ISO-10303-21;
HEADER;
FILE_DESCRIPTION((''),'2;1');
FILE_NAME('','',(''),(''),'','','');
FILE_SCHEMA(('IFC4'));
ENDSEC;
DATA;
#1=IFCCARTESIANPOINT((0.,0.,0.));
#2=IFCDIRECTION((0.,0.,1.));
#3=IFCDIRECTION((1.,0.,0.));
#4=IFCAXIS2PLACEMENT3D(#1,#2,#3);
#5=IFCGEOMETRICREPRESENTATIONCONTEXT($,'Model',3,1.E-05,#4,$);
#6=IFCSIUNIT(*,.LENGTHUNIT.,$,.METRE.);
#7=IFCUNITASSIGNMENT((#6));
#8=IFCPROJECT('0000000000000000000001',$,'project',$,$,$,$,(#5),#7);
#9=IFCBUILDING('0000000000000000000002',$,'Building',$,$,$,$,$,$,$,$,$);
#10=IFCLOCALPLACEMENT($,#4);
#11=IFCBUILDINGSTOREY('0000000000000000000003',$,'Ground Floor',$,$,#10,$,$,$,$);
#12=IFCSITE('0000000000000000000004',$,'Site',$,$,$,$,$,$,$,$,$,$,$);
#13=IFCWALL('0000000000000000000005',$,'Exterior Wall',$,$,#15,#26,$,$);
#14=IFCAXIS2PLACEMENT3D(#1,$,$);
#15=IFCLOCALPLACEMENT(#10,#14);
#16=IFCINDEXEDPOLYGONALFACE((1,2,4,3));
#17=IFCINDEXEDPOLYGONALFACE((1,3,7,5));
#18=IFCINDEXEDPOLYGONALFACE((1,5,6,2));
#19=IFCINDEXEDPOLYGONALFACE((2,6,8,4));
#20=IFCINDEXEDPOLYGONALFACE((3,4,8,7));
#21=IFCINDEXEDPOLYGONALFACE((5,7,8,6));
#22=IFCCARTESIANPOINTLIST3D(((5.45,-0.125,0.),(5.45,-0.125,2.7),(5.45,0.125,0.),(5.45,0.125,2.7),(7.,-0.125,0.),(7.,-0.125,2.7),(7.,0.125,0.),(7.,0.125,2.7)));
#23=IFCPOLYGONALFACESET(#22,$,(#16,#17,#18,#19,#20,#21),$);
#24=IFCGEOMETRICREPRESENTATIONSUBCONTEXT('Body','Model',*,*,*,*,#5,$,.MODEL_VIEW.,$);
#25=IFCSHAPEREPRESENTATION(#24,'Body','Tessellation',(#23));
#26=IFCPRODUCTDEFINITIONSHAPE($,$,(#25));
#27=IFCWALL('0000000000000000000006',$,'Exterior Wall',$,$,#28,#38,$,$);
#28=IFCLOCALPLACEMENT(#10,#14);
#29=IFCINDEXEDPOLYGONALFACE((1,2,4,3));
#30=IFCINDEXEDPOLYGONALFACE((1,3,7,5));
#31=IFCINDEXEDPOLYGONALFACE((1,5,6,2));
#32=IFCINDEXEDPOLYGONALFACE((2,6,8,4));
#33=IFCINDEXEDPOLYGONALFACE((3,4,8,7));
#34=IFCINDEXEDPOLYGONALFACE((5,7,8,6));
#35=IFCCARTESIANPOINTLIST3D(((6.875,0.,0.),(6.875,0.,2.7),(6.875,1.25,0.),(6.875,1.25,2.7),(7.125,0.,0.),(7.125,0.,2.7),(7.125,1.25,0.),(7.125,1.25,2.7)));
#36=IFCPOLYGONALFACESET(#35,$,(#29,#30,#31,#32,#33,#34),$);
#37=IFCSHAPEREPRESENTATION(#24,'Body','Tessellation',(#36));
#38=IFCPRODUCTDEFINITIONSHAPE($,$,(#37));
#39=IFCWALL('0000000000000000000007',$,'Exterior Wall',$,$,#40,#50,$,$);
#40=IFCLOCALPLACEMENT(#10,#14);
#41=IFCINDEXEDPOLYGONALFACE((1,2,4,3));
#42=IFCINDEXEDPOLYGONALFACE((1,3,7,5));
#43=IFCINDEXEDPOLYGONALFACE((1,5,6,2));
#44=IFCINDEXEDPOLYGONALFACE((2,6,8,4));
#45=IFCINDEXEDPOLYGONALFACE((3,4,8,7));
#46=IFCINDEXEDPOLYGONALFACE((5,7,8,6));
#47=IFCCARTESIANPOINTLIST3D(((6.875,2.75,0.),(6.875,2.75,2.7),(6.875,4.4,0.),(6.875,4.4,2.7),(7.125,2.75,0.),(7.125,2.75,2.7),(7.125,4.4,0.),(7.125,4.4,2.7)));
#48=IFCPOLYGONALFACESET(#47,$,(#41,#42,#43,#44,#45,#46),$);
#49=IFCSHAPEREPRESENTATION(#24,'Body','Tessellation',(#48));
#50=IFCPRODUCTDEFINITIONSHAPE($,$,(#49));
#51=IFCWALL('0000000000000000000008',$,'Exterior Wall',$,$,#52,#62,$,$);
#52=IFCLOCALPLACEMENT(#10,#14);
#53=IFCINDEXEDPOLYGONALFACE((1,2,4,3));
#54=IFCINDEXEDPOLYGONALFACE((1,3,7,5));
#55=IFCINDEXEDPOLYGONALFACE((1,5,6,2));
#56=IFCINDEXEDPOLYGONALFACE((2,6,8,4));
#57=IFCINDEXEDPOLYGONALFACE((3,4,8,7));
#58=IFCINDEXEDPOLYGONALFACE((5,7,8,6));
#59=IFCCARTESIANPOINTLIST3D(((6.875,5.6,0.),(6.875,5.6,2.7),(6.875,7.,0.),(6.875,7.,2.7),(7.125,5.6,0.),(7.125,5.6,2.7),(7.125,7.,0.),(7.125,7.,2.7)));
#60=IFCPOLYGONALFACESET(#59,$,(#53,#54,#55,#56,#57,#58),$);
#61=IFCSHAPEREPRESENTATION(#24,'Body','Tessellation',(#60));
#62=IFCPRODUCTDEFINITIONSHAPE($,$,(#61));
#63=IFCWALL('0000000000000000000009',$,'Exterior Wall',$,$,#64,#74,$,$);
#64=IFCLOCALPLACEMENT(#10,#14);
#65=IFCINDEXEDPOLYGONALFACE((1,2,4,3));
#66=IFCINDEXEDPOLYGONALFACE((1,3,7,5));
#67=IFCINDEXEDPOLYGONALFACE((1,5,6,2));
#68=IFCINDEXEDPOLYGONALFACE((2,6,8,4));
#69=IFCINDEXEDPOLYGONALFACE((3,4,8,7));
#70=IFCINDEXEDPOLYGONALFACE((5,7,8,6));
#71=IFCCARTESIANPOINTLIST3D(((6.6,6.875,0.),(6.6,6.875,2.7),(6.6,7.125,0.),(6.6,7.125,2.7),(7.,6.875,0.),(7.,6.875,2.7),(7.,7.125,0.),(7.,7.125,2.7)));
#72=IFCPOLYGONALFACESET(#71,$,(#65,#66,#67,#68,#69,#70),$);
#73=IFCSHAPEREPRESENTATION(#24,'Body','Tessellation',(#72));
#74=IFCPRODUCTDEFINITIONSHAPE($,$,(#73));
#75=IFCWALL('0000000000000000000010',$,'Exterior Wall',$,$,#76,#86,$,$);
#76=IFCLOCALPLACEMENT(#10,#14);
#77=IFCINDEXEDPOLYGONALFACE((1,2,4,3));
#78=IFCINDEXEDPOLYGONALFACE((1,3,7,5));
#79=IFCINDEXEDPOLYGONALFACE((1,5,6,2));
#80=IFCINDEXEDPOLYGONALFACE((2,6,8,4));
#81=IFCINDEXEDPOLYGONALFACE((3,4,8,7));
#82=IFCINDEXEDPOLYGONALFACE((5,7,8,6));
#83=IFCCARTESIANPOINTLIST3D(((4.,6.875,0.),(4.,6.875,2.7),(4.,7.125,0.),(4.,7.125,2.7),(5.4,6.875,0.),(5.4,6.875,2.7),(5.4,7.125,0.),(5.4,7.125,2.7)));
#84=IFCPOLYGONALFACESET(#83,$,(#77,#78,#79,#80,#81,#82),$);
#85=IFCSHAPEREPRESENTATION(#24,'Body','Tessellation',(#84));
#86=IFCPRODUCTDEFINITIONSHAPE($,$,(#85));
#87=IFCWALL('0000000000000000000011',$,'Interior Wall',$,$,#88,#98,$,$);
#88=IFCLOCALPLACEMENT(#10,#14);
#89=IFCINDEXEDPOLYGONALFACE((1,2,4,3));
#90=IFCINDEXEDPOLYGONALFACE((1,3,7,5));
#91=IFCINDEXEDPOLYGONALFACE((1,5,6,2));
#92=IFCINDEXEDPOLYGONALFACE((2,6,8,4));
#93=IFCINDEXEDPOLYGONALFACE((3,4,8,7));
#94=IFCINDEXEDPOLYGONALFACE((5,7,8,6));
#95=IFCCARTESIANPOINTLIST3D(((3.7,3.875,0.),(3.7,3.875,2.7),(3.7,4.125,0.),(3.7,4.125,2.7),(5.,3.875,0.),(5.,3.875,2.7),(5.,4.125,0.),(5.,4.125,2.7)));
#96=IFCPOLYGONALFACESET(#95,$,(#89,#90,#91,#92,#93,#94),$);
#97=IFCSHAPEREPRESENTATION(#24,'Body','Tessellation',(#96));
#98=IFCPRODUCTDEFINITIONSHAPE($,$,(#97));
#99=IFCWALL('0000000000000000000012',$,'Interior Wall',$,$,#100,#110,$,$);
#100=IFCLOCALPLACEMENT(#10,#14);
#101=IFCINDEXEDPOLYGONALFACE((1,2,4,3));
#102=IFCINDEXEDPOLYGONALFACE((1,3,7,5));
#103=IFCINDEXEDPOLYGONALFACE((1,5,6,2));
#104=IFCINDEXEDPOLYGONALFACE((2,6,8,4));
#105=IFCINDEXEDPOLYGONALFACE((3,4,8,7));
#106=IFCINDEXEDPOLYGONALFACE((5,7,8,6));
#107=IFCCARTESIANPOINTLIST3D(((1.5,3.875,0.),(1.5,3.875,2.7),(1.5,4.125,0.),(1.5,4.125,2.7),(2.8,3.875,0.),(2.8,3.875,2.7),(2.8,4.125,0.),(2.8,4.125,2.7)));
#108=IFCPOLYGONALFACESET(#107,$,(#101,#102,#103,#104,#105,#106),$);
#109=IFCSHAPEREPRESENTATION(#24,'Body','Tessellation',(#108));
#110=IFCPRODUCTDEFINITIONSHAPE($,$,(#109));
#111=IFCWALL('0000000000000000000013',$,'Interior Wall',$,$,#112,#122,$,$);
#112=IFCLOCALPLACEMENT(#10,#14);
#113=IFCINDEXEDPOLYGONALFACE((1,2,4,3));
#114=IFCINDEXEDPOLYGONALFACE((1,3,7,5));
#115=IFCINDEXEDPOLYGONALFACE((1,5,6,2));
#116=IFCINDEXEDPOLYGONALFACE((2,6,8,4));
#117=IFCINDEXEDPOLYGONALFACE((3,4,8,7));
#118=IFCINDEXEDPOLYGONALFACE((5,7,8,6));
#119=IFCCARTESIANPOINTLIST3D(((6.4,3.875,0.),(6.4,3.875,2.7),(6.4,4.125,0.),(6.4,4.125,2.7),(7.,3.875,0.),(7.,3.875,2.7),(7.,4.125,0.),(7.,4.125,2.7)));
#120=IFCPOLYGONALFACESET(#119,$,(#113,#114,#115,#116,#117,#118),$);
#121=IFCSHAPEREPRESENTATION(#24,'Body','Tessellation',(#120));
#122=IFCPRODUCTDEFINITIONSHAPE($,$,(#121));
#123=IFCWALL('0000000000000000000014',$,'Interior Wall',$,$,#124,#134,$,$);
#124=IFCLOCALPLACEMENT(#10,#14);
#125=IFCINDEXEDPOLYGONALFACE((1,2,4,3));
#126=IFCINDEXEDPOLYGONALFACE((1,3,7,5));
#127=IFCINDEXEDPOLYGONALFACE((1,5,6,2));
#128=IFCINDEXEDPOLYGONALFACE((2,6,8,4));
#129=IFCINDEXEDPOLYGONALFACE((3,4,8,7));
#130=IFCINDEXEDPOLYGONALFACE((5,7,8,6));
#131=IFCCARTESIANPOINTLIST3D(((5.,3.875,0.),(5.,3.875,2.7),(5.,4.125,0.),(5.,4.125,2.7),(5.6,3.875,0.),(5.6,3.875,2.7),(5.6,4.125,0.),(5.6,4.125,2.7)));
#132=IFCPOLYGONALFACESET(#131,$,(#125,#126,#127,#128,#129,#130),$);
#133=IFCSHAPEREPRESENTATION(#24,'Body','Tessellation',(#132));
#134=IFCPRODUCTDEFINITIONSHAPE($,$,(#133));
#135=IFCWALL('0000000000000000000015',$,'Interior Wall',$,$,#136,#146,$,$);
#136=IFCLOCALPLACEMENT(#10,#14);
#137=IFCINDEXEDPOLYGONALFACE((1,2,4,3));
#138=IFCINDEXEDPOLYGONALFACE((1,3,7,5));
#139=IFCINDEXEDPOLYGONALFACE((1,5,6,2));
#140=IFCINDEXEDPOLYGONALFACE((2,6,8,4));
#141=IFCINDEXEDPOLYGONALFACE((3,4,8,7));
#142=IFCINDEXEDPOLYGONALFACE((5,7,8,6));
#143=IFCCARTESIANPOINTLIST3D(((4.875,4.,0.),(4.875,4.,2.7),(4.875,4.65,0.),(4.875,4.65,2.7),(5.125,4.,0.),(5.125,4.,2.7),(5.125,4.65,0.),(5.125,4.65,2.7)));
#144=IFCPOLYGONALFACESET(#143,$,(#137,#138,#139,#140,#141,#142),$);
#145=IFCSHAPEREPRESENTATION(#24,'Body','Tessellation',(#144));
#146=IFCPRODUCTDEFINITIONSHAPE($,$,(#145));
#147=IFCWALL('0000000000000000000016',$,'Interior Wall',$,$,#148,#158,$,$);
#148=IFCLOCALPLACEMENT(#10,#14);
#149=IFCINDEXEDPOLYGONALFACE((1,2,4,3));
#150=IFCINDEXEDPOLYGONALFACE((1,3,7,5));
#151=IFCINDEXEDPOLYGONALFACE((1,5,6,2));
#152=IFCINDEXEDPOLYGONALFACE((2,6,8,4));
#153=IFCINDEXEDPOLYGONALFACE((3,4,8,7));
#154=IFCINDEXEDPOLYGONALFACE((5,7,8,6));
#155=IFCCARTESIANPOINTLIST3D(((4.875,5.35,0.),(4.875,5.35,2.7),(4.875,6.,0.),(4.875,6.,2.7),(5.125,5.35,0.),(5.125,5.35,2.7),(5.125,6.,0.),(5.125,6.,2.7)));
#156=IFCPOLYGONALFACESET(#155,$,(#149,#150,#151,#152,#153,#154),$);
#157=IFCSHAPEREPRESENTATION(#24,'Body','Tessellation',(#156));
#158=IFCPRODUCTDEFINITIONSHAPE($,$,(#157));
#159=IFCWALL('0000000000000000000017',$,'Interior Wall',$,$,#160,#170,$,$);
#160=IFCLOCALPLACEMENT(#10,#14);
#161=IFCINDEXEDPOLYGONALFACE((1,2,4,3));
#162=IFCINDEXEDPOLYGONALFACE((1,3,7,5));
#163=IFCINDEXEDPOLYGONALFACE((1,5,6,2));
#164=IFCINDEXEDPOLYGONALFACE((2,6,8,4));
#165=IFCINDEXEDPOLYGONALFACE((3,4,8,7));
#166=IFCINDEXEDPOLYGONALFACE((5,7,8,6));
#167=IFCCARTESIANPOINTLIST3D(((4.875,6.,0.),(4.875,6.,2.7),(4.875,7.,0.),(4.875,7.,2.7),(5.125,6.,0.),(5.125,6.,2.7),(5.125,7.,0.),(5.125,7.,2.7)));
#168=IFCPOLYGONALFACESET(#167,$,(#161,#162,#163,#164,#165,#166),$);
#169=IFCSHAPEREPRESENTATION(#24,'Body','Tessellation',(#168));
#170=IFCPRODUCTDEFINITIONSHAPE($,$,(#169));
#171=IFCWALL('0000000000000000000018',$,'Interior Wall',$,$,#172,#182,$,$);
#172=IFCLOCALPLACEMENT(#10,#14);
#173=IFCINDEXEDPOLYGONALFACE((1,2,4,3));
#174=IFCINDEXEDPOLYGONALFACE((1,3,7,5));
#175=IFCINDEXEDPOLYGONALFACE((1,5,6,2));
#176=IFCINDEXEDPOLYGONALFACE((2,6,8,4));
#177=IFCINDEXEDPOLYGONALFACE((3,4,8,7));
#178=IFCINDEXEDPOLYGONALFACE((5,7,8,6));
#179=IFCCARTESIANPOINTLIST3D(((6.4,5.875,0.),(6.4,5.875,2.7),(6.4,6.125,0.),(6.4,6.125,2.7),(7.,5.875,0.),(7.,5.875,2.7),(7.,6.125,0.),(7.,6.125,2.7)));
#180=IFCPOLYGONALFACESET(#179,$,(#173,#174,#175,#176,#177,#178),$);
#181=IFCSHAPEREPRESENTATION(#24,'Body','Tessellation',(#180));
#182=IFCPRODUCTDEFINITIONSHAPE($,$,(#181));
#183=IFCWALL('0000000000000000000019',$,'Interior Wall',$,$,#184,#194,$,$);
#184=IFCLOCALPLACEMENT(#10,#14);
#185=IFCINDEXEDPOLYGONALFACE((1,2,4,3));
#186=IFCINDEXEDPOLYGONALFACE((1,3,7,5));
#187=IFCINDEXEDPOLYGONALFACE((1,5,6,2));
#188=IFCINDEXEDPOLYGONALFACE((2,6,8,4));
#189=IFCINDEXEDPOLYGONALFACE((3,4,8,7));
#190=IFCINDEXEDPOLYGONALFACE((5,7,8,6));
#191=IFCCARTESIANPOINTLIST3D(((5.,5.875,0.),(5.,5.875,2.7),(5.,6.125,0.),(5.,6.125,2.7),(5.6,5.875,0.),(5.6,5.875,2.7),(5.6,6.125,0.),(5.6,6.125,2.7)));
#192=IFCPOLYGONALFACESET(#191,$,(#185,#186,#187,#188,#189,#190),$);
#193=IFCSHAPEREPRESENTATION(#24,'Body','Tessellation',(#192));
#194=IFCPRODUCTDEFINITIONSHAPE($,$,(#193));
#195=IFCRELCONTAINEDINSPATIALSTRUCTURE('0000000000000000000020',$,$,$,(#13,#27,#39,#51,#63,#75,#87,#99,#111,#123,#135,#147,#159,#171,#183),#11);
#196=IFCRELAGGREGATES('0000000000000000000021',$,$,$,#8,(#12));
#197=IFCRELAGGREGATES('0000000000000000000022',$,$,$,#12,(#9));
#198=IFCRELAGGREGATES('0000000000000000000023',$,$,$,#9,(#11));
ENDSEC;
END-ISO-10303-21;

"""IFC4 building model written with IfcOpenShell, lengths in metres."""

from ifc_helpers import new_model, si_unit, frame, origin_with_axes, place, context, subcontext, project, spatial, indexed_curve, outline, extrude, element, save


model = new_model("IFC4")

# Units and contexts
model_context = context("Model", 3, precision=1e-05, world=origin_with_axes())
body_context = subcontext(model_context, "Body", "Model", "MODEL_VIEW")
ifc_project = project(units=[si_unit("LENGTHUNIT", "METRE")], contexts=[model_context])

# Site, building, storey
site = spatial("IfcSite", under=ifc_project, Name="Site")
building = spatial("IfcBuilding", under=site, Name="Building")
storey_placement = place(None, origin_with_axes())
storey = spatial("IfcBuildingStorey", under=building, at=storey_placement, Name="Ground Floor")

# Walls
wall_1_placement = place(storey_placement, frame((5.45, 0.0, 0.0), z_axis=(0.0, 0.0, 1.0), x_axis=(1.0, 0.0, 0.0)))
element("IfcWall", 1, at=wall_1_placement, inside=storey, Name="Exterior Wall", context=body_context, shape_type="SweptSolid", body=[
    extrude(outline(indexed_curve([(0.0, 0.0), (0.0, 0.25), (1.55, 0.25), (1.55, 0.0), (0.0, 0.0)], self_intersect=False)), frame((0.0, -0.125, 0.0), z_axis=(0.0, 0.0, 1.0), x_axis=(1.0, 0.0, 0.0)), (0.0, 0.0, 1.0), 2.7),
])
wall_2_placement = place(storey_placement, frame((7.0, 0.0, 0.0), z_axis=(0.0, 0.0, 1.0), x_axis=(0.0, 1.0, 0.0)))
element("IfcWall", 2, at=wall_2_placement, inside=storey, Name="Exterior Wall", context=body_context, shape_type="SweptSolid", body=[
    extrude(outline(indexed_curve([(0.0, 0.0), (0.0, 0.25), (1.25, 0.25), (1.25, 0.0), (0.0, 0.0)], self_intersect=False)), frame((0.0, -0.125, 0.0), z_axis=(0.0, 0.0, 1.0), x_axis=(1.0, 0.0, 0.0)), (0.0, 0.0, 1.0), 2.7),
])
wall_3_placement = place(storey_placement, frame((7.0, 2.75, 0.0), z_axis=(0.0, 0.0, 1.0), x_axis=(0.0, 1.0, 0.0)))
element("IfcWall", 3, at=wall_3_placement, inside=storey, Name="Exterior Wall", context=body_context, shape_type="SweptSolid", body=[
    extrude(outline(indexed_curve([(0.0, 0.0), (0.0, 0.25), (1.65, 0.25), (1.65, 0.0), (0.0, 0.0)], self_intersect=False)), frame((0.0, -0.125, 0.0), z_axis=(0.0, 0.0, 1.0), x_axis=(1.0, 0.0, 0.0)), (0.0, 0.0, 1.0), 2.7),
])
wall_4_placement = place(storey_placement, frame((7.0, 5.6, 0.0), z_axis=(0.0, 0.0, 1.0), x_axis=(0.0, 1.0, 0.0)))
element("IfcWall", 4, at=wall_4_placement, inside=storey, Name="Exterior Wall", context=body_context, shape_type="SweptSolid", body=[
    extrude(outline(indexed_curve([(0.0, 0.0), (0.0, 0.25), (1.4, 0.25), (1.4, 0.0), (0.0, 0.0)], self_intersect=False)), frame((0.0, -0.125, 0.0), z_axis=(0.0, 0.0, 1.0), x_axis=(1.0, 0.0, 0.0)), (0.0, 0.0, 1.0), 2.7),
])
wall_5_placement = place(storey_placement, frame((7.0, 7.0, 0.0), z_axis=(0.0, 0.0, 1.0), x_axis=(-1.0, 0.0, 0.0)))
element("IfcWall", 5, at=wall_5_placement, inside=storey, Name="Exterior Wall", context=body_context, shape_type="SweptSolid", body=[
    extrude(outline(indexed_curve([(0.0, 0.0), (0.0, 0.25), (0.4, 0.25), (0.4, 0.0), (0.0, 0.0)], self_intersect=False)), frame((0.0, -0.125, 0.0), z_axis=(0.0, 0.0, 1.0), x_axis=(1.0, 0.0, 0.0)), (0.0, 0.0, 1.0), 2.7),
])
wall_6_placement = place(storey_placement, frame((5.4, 7.0, 0.0), z_axis=(0.0, 0.0, 1.0), x_axis=(-1.0, 0.0, 0.0)))
element("IfcWall", 6, at=wall_6_placement, inside=storey, Name="Exterior Wall", context=body_context, shape_type="SweptSolid", body=[
    extrude(outline(indexed_curve([(0.0, 0.0), (0.0, 0.25), (1.4, 0.25), (1.4, 0.0), (0.0, 0.0)], self_intersect=False)), frame((0.0, -0.125, 0.0), z_axis=(0.0, 0.0, 1.0), x_axis=(1.0, 0.0, 0.0)), (0.0, 0.0, 1.0), 2.7),
])
for number, where, z_axis, x_axis, name in (
    (7, (5.0, 4.0, 0.0), (0.0, 0.0, 1.0), (-1.0, 0.0, 0.0), "Interior Wall"),
    (8, (2.8, 4.0, 0.0), (0.0, 0.0, 1.0), (-1.0, 0.0, 0.0), "Interior Wall"),
):
    element("IfcWall", number, at=place(storey_placement, frame(where, z_axis=z_axis, x_axis=x_axis)), inside=storey, Name=name, context=body_context, shape_type="SweptSolid", body=[
        extrude(outline(indexed_curve([(0.0, 0.0), (0.0, 0.25), (1.3, 0.25), (1.3, 0.0), (0.0, 0.0)], self_intersect=False)), frame((0.0, -0.125, 0.0), z_axis=(0.0, 0.0, 1.0), x_axis=(1.0, 0.0, 0.0)), (0.0, 0.0, 1.0), 2.7),
    ])
for number, where, z_axis, x_axis, name in (
    (9, (7.0, 4.0, 0.0), (0.0, 0.0, 1.0), (-1.0, 0.0, 0.0), "Interior Wall"),
    (10, (5.6, 4.0, 0.0), (0.0, 0.0, 1.0), (-1.0, 0.0, 0.0), "Interior Wall"),
):
    element("IfcWall", number, at=place(storey_placement, frame(where, z_axis=z_axis, x_axis=x_axis)), inside=storey, Name=name, context=body_context, shape_type="SweptSolid", body=[
        extrude(outline(indexed_curve([(0.0, 0.0), (0.0, 0.25), (0.6, 0.25), (0.6, 0.0), (0.0, 0.0)], self_intersect=False)), frame((0.0, -0.125, 0.0), z_axis=(0.0, 0.0, 1.0), x_axis=(1.0, 0.0, 0.0)), (0.0, 0.0, 1.0), 2.7),
    ])
for number, where, z_axis, x_axis, name in (
    (11, (5.0, 4.0, 0.0), (0.0, 0.0, 1.0), (0.0, 1.0, 0.0), "Interior Wall"),
    (12, (5.0, 5.35, 0.0), (0.0, 0.0, 1.0), (0.0, 1.0, 0.0), "Interior Wall"),
):
    element("IfcWall", number, at=place(storey_placement, frame(where, z_axis=z_axis, x_axis=x_axis)), inside=storey, Name=name, context=body_context, shape_type="SweptSolid", body=[
        extrude(outline(indexed_curve([(0.0, 0.0), (0.0, 0.25), (0.65, 0.25), (0.65, 0.0), (0.0, 0.0)], self_intersect=False)), frame((0.0, -0.125, 0.0), z_axis=(0.0, 0.0, 1.0), x_axis=(1.0, 0.0, 0.0)), (0.0, 0.0, 1.0), 2.7),
    ])
wall_7_placement = place(storey_placement, frame((5.0, 6.0, 0.0), z_axis=(0.0, 0.0, 1.0), x_axis=(0.0, 1.0, 0.0)))
element("IfcWall", 13, at=wall_7_placement, inside=storey, Name="Interior Wall", context=body_context, shape_type="SweptSolid", body=[
    extrude(outline(indexed_curve([(0.0, 0.0), (0.0, 0.25), (1.0, 0.25), (1.0, 0.0), (0.0, 0.0)], self_intersect=False)), frame((0.0, -0.125, 0.0), z_axis=(0.0, 0.0, 1.0), x_axis=(1.0, 0.0, 0.0)), (0.0, 0.0, 1.0), 2.7),
])
for number, where, z_axis, x_axis, name in (
    (14, (7.0, 6.0, 0.0), (0.0, 0.0, 1.0), (-1.0, 0.0, 0.0), "Interior Wall"),
    (15, (5.6, 6.0, 0.0), (0.0, 0.0, 1.0), (-1.0, 0.0, 0.0), "Interior Wall"),
):
    element("IfcWall", number, at=place(storey_placement, frame(where, z_axis=z_axis, x_axis=x_axis)), inside=storey, Name=name, context=body_context, shape_type="SweptSolid", body=[
        extrude(outline(indexed_curve([(0.0, 0.0), (0.0, 0.25), (0.6, 0.25), (0.6, 0.0), (0.0, 0.0)], self_intersect=False)), frame((0.0, -0.125, 0.0), z_axis=(0.0, 0.0, 1.0), x_axis=(1.0, 0.0, 0.0)), (0.0, 0.0, 1.0), 2.7),
    ])

save(model, "model.ifc")
